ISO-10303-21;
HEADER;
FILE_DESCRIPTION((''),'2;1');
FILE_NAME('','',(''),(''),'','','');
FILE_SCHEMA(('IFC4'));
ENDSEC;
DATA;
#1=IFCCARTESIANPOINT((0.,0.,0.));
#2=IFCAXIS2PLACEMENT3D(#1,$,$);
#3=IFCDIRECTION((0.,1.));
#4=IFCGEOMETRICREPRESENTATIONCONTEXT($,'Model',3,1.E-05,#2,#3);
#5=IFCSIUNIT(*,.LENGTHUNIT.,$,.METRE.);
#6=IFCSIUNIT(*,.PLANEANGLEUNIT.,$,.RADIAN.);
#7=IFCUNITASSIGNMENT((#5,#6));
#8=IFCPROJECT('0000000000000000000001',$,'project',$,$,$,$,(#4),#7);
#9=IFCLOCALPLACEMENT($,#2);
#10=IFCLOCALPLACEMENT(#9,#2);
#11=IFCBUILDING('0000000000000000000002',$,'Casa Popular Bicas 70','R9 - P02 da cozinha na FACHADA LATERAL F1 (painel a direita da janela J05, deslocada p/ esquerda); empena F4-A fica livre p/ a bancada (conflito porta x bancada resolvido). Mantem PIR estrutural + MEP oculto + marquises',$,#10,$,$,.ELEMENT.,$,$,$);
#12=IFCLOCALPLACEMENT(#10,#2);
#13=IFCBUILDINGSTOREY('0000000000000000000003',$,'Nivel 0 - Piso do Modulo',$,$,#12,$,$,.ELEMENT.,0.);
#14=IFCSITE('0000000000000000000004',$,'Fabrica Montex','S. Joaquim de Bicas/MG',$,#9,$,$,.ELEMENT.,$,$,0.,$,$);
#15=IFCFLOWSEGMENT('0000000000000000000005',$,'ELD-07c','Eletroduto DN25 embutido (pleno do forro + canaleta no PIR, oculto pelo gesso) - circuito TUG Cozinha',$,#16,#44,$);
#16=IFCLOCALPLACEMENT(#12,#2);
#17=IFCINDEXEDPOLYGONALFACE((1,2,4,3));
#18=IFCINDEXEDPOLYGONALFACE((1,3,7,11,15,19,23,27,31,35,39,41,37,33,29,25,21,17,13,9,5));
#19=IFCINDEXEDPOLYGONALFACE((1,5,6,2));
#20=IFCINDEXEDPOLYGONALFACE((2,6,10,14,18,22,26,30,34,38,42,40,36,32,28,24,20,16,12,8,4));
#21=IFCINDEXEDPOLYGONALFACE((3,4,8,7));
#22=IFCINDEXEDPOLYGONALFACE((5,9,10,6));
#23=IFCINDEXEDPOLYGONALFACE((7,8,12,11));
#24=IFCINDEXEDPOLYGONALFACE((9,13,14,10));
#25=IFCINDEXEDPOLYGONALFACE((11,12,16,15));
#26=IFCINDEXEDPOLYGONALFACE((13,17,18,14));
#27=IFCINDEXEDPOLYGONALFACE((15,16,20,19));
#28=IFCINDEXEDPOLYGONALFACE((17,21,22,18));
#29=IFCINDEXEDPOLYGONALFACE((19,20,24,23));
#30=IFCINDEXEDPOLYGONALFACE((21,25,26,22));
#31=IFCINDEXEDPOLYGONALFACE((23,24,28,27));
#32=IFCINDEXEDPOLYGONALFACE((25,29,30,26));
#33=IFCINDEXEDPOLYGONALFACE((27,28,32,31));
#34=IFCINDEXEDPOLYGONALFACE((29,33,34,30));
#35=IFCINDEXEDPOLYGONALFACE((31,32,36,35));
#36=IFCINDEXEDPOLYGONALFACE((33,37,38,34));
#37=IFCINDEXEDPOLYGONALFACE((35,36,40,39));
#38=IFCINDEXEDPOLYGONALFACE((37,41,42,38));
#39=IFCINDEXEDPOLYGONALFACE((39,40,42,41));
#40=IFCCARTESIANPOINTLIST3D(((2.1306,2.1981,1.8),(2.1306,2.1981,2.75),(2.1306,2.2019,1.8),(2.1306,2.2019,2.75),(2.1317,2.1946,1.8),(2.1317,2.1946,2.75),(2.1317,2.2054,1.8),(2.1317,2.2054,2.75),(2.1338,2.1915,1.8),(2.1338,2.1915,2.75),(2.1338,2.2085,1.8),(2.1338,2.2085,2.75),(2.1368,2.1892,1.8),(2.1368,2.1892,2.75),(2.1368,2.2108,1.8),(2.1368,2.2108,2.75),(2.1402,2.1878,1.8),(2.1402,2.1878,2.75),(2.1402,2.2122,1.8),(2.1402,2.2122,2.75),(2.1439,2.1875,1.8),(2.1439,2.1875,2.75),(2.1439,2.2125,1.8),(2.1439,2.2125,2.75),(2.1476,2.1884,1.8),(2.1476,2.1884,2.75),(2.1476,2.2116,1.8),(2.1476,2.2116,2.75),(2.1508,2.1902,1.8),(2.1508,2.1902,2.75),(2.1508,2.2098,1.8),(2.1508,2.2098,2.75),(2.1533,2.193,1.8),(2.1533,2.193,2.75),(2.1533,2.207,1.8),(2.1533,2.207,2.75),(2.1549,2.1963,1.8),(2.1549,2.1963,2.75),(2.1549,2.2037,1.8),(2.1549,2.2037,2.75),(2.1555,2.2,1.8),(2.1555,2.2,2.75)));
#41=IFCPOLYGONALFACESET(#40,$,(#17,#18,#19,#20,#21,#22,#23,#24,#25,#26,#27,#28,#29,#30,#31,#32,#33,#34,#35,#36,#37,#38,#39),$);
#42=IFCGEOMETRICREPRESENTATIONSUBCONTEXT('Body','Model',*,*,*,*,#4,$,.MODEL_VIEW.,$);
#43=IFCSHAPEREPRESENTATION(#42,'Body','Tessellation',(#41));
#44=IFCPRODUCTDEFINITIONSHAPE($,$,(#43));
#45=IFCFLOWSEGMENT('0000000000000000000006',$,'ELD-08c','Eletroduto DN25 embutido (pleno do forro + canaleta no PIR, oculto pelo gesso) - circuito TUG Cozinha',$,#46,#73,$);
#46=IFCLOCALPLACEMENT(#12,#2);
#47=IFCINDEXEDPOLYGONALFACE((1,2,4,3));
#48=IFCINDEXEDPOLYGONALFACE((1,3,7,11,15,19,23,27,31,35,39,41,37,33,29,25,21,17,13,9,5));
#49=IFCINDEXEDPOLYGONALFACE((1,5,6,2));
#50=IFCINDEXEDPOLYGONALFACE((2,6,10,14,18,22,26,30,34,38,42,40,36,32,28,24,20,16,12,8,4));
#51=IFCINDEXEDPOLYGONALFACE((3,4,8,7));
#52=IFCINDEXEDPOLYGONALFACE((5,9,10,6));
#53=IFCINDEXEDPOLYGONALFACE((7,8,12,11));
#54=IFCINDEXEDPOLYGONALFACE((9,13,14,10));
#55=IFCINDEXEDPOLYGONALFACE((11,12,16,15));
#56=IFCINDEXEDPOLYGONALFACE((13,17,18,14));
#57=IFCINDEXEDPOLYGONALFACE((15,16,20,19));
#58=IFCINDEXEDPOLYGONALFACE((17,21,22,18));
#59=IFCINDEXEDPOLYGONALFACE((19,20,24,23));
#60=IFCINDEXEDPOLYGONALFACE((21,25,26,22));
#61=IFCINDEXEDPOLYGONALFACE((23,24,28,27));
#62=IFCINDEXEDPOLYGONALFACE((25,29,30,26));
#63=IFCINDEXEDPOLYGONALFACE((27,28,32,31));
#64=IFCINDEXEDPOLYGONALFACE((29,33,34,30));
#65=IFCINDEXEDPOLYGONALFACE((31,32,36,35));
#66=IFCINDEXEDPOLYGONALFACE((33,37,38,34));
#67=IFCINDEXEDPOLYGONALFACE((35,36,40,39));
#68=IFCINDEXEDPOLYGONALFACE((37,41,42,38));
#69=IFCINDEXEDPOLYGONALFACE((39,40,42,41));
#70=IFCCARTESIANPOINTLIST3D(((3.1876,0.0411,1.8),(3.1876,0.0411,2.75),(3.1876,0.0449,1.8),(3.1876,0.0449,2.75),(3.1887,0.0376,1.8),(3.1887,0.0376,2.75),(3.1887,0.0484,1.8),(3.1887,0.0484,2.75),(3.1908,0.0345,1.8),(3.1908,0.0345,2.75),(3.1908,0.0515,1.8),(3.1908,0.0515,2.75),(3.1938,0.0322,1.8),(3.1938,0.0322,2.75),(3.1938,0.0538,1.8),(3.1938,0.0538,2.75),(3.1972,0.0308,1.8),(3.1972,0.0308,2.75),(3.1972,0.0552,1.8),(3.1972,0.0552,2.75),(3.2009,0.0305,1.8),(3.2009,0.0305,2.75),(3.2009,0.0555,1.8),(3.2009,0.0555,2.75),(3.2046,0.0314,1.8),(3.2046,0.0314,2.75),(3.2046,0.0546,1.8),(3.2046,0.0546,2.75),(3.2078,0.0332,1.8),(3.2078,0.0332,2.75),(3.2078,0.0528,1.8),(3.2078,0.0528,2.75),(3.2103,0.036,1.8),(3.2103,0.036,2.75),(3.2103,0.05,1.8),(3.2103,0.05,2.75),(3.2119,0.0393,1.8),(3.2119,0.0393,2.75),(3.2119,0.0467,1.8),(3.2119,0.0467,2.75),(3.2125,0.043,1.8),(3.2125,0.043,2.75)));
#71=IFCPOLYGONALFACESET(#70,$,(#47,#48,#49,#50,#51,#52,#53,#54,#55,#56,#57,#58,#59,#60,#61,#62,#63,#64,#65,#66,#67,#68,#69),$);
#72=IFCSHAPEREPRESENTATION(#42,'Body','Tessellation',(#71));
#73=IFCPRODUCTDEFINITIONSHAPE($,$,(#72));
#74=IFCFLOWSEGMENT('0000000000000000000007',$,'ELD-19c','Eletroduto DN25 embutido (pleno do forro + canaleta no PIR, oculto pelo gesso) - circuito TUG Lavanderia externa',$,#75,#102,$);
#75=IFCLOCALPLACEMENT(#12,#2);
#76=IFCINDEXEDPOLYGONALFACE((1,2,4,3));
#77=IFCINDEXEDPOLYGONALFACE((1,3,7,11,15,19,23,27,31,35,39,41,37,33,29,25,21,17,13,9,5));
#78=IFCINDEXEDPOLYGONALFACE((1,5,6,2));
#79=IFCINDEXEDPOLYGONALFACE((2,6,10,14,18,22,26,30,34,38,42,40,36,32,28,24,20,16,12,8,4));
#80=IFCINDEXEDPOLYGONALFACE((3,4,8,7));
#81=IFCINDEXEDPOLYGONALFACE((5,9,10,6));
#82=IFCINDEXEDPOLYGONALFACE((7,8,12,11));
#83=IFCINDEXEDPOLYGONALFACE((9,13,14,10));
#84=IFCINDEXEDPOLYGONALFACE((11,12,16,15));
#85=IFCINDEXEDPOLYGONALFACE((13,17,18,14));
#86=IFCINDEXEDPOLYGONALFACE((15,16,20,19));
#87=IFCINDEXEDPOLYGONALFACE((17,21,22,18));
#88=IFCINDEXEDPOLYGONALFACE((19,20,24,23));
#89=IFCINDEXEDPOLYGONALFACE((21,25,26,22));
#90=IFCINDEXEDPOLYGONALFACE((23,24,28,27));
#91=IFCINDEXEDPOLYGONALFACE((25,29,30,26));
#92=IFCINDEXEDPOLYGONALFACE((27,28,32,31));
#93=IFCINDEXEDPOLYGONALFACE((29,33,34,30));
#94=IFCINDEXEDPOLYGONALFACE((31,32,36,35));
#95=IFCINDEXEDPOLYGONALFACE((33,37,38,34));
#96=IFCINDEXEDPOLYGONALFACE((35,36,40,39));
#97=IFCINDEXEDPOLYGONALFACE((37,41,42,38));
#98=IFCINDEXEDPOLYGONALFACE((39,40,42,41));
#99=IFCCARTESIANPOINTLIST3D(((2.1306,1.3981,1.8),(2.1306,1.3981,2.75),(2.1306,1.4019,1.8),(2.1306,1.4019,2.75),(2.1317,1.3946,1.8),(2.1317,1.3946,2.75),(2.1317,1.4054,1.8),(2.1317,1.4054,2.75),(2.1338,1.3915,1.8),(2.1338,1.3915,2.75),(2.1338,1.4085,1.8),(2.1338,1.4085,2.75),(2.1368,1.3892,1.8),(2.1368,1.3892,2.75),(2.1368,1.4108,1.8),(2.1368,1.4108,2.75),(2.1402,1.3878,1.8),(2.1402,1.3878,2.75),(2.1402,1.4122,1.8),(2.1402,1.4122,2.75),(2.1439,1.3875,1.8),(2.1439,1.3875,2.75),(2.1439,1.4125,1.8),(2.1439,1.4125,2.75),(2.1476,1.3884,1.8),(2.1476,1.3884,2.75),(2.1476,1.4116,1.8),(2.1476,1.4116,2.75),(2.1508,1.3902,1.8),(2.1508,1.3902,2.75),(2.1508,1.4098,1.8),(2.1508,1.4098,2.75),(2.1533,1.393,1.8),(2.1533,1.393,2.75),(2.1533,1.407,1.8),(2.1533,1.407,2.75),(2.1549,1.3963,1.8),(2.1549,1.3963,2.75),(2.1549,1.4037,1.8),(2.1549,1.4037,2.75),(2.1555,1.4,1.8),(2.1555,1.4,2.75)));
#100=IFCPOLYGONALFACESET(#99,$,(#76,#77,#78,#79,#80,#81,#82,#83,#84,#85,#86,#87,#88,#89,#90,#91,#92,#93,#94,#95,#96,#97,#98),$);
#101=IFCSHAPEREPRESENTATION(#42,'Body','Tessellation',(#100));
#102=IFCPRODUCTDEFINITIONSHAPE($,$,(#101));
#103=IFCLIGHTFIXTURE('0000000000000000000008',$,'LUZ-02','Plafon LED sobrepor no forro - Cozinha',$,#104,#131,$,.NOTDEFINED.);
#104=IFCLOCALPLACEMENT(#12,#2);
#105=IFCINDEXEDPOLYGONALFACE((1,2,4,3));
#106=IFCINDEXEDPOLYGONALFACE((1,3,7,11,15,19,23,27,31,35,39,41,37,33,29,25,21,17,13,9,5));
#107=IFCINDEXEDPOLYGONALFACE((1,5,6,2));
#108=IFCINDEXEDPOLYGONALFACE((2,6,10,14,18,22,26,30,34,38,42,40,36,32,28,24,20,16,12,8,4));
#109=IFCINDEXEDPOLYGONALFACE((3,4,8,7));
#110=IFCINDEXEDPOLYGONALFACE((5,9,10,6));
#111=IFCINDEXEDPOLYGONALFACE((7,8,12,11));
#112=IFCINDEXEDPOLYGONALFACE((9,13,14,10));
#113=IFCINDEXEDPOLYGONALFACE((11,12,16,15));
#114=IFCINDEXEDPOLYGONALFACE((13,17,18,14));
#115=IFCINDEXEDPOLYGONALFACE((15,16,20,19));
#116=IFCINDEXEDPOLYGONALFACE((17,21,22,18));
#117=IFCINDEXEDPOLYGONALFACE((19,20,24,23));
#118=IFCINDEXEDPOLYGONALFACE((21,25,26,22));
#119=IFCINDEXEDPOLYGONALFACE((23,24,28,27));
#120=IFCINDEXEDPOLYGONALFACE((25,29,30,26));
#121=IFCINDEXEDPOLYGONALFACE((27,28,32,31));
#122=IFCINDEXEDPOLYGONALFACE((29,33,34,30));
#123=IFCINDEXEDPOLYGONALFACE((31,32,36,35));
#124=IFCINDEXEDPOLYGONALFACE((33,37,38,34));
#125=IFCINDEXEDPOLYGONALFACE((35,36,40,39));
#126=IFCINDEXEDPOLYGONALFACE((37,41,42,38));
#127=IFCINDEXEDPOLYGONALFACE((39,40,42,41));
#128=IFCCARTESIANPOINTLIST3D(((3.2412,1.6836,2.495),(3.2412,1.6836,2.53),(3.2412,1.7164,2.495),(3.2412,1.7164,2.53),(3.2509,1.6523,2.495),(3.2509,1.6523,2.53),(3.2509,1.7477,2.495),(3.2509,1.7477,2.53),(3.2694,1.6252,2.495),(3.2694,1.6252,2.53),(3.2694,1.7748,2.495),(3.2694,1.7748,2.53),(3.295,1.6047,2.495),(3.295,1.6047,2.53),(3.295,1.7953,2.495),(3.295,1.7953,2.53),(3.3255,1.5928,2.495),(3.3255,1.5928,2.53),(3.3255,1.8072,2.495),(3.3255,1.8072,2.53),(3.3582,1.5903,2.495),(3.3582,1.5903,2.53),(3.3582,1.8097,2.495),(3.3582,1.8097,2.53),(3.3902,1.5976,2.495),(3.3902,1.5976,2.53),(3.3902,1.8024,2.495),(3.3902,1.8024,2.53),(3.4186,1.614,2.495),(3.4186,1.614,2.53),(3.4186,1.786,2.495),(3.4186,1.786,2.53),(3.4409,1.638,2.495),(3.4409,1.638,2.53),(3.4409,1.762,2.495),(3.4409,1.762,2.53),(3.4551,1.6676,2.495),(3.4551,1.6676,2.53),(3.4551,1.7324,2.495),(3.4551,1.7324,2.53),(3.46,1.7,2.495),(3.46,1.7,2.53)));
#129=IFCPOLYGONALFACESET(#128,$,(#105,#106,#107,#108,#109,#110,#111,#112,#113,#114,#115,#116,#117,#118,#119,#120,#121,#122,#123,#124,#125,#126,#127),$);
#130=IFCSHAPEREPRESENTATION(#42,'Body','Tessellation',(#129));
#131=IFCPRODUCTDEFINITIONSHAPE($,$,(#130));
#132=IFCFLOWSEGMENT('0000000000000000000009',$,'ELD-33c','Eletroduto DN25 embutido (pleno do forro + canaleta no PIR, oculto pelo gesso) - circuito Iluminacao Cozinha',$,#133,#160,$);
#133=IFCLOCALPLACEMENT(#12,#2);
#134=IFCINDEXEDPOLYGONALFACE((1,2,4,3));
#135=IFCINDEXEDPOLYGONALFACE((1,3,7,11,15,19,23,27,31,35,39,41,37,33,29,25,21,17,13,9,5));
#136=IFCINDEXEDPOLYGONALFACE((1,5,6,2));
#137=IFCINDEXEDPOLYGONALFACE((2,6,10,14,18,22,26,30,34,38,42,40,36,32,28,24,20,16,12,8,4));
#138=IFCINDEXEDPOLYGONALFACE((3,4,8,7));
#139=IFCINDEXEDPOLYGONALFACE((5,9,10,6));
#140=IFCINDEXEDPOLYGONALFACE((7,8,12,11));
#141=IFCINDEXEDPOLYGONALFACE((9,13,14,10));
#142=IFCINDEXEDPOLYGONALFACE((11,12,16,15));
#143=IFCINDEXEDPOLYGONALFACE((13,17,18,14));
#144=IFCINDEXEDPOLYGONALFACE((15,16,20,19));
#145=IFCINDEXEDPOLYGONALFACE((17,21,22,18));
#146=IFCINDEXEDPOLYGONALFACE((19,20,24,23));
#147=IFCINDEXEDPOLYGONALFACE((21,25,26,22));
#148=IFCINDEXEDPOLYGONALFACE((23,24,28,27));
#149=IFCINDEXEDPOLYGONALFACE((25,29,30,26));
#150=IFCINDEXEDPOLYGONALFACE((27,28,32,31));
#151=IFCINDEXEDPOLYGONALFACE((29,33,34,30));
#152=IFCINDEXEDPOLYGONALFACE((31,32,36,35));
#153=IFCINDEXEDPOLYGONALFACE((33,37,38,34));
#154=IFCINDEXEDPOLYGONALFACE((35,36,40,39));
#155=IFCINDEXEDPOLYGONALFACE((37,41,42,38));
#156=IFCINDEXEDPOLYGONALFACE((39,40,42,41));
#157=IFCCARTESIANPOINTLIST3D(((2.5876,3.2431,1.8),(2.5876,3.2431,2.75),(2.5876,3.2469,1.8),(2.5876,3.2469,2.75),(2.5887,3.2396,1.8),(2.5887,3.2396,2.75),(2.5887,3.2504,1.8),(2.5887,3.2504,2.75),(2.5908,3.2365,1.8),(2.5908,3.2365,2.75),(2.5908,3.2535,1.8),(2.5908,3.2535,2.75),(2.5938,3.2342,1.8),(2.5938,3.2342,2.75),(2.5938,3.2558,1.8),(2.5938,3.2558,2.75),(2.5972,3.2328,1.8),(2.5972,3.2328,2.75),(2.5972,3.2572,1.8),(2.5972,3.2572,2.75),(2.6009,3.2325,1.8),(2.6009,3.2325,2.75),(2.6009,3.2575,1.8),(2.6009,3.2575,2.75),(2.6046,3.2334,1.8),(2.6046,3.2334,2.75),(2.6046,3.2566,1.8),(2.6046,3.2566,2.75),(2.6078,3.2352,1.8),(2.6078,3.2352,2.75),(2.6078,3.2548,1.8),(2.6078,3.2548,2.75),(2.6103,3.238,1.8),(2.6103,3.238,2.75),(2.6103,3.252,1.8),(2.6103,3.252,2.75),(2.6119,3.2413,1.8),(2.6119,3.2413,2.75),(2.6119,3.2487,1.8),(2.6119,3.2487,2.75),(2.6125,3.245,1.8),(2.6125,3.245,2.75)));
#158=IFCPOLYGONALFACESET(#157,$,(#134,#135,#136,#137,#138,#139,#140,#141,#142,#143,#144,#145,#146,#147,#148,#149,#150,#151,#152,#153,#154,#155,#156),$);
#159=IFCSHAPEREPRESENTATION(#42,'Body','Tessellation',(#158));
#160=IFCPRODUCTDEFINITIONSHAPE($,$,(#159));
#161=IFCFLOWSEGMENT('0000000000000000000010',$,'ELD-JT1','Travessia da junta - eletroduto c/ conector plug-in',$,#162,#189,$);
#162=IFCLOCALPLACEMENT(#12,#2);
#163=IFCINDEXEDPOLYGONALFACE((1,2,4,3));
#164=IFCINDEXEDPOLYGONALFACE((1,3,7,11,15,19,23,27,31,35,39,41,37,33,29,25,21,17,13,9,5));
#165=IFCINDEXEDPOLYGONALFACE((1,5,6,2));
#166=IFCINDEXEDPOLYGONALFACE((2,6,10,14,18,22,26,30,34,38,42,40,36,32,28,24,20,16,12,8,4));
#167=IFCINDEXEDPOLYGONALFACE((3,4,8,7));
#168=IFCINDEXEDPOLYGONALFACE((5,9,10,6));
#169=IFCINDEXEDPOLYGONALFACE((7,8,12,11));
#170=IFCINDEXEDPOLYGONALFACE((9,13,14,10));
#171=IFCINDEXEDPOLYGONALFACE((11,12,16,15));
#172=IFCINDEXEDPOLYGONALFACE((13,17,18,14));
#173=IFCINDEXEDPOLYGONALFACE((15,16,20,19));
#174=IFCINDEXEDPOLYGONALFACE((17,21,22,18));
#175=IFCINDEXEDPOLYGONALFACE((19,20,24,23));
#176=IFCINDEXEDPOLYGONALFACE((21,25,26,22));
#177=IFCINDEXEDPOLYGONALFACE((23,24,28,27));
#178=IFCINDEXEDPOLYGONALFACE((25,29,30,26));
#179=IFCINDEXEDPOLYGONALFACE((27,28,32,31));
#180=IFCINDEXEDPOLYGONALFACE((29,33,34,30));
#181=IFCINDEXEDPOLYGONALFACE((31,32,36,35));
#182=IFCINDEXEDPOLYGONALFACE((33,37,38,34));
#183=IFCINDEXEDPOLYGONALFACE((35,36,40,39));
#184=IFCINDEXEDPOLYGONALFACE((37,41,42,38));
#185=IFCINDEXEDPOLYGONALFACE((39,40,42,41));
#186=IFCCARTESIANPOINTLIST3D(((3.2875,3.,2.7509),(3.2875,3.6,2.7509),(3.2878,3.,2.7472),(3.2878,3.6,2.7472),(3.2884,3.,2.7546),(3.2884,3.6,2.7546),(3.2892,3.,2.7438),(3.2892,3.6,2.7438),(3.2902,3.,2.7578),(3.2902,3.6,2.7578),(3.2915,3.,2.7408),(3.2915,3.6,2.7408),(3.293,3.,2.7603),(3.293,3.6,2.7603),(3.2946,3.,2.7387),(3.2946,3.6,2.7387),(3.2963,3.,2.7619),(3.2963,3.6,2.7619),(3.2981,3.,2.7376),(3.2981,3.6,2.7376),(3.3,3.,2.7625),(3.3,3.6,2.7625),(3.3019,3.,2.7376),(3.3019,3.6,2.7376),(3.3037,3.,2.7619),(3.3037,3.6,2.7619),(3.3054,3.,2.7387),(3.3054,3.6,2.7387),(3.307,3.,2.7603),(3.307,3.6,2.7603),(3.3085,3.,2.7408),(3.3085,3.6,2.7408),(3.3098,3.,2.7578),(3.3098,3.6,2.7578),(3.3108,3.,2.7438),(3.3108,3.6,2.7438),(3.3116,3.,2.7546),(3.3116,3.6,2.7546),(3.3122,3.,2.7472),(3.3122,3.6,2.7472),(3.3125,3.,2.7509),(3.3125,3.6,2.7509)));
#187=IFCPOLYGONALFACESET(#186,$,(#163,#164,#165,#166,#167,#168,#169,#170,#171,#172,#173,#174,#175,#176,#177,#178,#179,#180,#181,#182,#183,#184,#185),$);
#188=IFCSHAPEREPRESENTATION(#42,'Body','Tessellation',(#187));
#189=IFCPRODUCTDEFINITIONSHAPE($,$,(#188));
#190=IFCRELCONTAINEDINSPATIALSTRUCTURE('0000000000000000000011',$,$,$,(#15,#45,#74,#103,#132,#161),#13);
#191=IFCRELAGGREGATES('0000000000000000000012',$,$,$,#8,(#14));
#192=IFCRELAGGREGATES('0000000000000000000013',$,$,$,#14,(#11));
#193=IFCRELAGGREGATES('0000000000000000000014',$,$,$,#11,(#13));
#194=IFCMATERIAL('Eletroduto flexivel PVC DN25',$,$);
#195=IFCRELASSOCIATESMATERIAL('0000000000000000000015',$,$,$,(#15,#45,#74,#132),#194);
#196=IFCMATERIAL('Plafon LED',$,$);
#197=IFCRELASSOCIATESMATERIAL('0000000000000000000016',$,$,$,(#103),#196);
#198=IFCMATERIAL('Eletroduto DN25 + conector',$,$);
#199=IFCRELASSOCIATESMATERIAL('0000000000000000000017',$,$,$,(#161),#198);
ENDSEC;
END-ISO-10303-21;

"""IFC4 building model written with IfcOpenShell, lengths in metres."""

from ifc_helpers import new_model, si_unit, direction, frame, origin, origin_2d, place, context, subcontext, project, spatial, circle, extrude, material, element, save


model = new_model("IFC4")

# Units and contexts
model_context = context("Model", 3, precision=1e-05, world=origin(), true_north=direction((0.0, 1.0)))
body_context = subcontext(model_context, "Body", "Model", "MODEL_VIEW")
ifc_project = project(units=[si_unit("LENGTHUNIT", "METRE"), si_unit("PLANEANGLEUNIT", "RADIAN")], contexts=[model_context])

# Site, building, storey
site_placement = place(None, origin())
site = spatial("IfcSite", under=ifc_project, at=site_placement, Name="Fabrica Montex", Description="S. Joaquim de Bicas/MG", CompositionType="ELEMENT", RefElevation=0.0)
building_placement = place(site_placement, origin())
building = spatial("IfcBuilding", under=site, at=building_placement, Name="Casa Popular Bicas 70", Description="R9 - P02 da cozinha na FACHADA LATERAL F1 (painel a direita da janela J05, deslocada p/ esquerda); empena F4-A fica livre p/ a bancada (conflito porta x bancada resolvido). Mantem PIR estrutural + MEP oculto + marquises", CompositionType="ELEMENT")
storey_placement = place(building_placement, origin())
storey = spatial("IfcBuildingStorey", under=building, at=storey_placement, Name="Nivel 0 - Piso do Modulo", CompositionType="ELEMENT", Elevation=0.0)

# Flow segments
ifc_material_1 = material(Name="Eletroduto flexivel PVC DN25")
for number, where, z_axis, x_axis, name, description in (
    (1, (2.143, 2.2, 2.75), (0.0, 0.0, -1.0), (1.0, 0.0, 0.0), "ELD-07c", "Eletroduto DN25 embutido (pleno do forro + canaleta no PIR, oculto pelo gesso) - circuito TUG Cozinha"),
    (2, (3.2, 0.043, 2.75), (0.0, 0.0, -1.0), (1.0, 0.0, 0.0), "ELD-08c", "Eletroduto DN25 embutido (pleno do forro + canaleta no PIR, oculto pelo gesso) - circuito TUG Cozinha"),
    (3, (2.143, 1.4, 2.75), (0.0, 0.0, -1.0), (1.0, 0.0, 0.0), "ELD-19c", "Eletroduto DN25 embutido (pleno do forro + canaleta no PIR, oculto pelo gesso) - circuito TUG Lavanderia externa"),
):
    element("IfcFlowSegment", number, at=place(storey_placement, frame(where, z_axis=z_axis, x_axis=x_axis)), inside=storey, material=ifc_material_1, Name=name, Description=description, context=body_context, shape_type="SweptSolid", body=[
        extrude(circle(Radius=0.0125, at=origin_2d()), origin(), (0.0, 0.0, 1.0), 0.95),
    ])

# Light fixture
ifc_material_2 = material(Name="Plafon LED")
light_fixture_placement = place(storey_placement, frame((3.35, 1.7, 2.495)))
element("IfcLightFixture", 4, at=light_fixture_placement, inside=storey, material=ifc_material_2, Name="LUZ-02", Description="Plafon LED sobrepor no forro - Cozinha", PredefinedType="NOTDEFINED", context=body_context, shape_type="SweptSolid", body=[
    extrude(circle(Radius=0.11, at=origin_2d()), origin(), (0.0, 0.0, 1.0), 0.035),
])

# Flow segments
flow_segment_1_placement = place(storey_placement, frame((2.6, 3.245, 2.75), z_axis=(0.0, 0.0, -1.0), x_axis=(1.0, 0.0, 0.0)))
element("IfcFlowSegment", 5, at=flow_segment_1_placement, inside=storey, material=ifc_material_1, Name="ELD-33c", Description="Eletroduto DN25 embutido (pleno do forro + canaleta no PIR, oculto pelo gesso) - circuito Iluminacao Cozinha", context=body_context, shape_type="SweptSolid", body=[
    extrude(circle(Radius=0.0125, at=origin_2d()), origin(), (0.0, 0.0, 1.0), 0.95),
])
ifc_material_3 = material(Name="Eletroduto DN25 + conector")
for number, where, z_axis, x_axis, name in (
    (6, (3.3, 3.0, 2.75), (0.0, 1.0, 0.0), (0.0, 0.0, 1.0), "ELD-JT1"),
):
    element("IfcFlowSegment", number, at=place(storey_placement, frame(where, z_axis=z_axis, x_axis=x_axis)), inside=storey, material=ifc_material_3, Name=name, Description="Travessia da junta - eletroduto c/ conector plug-in", context=body_context, shape_type="SweptSolid", body=[
        extrude(circle(Radius=0.0125, at=origin_2d()), origin(), (0.0, 0.0, 1.0), 0.6),
    ])

save(model, "model.ifc")
